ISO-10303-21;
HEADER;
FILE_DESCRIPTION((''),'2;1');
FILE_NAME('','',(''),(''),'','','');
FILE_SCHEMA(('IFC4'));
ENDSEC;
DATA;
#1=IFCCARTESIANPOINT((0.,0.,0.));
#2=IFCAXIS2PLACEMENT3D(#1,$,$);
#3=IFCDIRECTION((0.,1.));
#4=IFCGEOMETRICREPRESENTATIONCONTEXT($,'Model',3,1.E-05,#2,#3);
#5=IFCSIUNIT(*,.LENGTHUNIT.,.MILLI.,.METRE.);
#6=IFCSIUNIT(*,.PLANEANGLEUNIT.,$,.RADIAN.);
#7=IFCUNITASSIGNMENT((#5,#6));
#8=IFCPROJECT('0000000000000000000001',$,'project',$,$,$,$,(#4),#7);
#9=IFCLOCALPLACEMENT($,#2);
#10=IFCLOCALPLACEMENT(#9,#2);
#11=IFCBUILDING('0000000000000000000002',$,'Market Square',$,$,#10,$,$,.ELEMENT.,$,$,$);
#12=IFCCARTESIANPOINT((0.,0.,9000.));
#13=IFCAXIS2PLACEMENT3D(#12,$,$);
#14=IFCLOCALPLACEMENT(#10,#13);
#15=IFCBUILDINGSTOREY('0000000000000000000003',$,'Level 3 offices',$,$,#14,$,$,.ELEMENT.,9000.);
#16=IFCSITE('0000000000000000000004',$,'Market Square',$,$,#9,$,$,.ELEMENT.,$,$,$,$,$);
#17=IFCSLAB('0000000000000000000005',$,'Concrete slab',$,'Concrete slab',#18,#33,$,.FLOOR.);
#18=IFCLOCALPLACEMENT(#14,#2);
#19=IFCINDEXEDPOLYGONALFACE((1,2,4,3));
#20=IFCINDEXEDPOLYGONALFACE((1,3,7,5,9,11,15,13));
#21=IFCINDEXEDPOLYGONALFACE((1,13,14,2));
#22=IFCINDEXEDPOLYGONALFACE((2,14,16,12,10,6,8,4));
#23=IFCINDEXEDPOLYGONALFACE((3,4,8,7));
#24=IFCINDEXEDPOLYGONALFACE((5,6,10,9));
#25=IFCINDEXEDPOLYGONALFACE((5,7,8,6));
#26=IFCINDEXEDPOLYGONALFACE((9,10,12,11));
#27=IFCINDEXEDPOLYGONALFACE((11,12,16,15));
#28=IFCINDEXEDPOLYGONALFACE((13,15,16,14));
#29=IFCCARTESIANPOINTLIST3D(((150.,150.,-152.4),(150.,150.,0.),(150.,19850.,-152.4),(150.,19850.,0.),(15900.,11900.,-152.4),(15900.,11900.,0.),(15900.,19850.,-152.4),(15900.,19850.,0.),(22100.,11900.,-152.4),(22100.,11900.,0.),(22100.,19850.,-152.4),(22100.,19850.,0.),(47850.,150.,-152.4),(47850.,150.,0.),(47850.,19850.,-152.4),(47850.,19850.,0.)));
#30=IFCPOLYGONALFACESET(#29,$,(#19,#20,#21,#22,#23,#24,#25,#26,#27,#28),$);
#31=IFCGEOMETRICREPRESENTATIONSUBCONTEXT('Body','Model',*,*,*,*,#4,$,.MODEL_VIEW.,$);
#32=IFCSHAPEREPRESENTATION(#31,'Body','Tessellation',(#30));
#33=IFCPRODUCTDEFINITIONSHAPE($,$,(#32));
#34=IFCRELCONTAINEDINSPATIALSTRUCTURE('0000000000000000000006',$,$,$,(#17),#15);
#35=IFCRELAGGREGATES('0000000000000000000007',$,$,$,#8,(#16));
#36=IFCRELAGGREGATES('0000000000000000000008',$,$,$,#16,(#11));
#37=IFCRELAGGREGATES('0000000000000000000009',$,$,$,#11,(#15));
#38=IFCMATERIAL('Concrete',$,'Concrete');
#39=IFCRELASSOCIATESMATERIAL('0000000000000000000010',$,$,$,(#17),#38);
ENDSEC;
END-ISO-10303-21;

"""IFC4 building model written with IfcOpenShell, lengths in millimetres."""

from ifc_helpers import new_model, si_unit, direction, frame, origin, origin_with_axes, place, context, subcontext, project, spatial, polyline, outline, extrude, material, element, save


model = new_model("IFC4")

# Units and contexts
model_context = context("Model", 3, precision=1e-05, world=origin(), true_north=direction((0.0, 1.0)))
body_context = subcontext(model_context, "Body", "Model", "MODEL_VIEW")
ifc_project = project(units=[si_unit("LENGTHUNIT", "METRE", prefix="MILLI"), si_unit("PLANEANGLEUNIT", "RADIAN")], contexts=[model_context])

# Site, building, storey
site_placement = place(None, origin())
site = spatial("IfcSite", under=ifc_project, at=site_placement, Name="Market Square", CompositionType="ELEMENT")
building_placement = place(site_placement, origin())
building = spatial("IfcBuilding", under=site, at=building_placement, Name="Market Square", CompositionType="ELEMENT")
storey_placement = place(building_placement, frame((0.0, 0.0, 9000.0)))
storey = spatial("IfcBuildingStorey", under=building, at=storey_placement, Name="Level 3 offices", CompositionType="ELEMENT", Elevation=9000.0)

# Slab
ifc_material_1 = material(Name="Concrete", Category="Concrete")
slab_placement = place(storey_placement, origin_with_axes())
element("IfcSlab", 1, at=slab_placement, inside=storey, material=ifc_material_1, Name="Concrete slab", ObjectType="Concrete slab", PredefinedType="FLOOR", context=body_context, shape_type="SweptSolid", body=[
    extrude(outline(polyline([(150.0, 150.0), (47850.0, 150.0), (47850.0, 19850.0), (22100.0, 19850.0), (22100.0, 11900.0), (15900.0, 11900.0), (15900.0, 19850.0), (150.0, 19850.0), (150.0, 150.0)])), frame((0.0, 0.0, -152.4)), (0.0, 0.0, 1.0), 152.4),
])

save(model, "model.ifc")
